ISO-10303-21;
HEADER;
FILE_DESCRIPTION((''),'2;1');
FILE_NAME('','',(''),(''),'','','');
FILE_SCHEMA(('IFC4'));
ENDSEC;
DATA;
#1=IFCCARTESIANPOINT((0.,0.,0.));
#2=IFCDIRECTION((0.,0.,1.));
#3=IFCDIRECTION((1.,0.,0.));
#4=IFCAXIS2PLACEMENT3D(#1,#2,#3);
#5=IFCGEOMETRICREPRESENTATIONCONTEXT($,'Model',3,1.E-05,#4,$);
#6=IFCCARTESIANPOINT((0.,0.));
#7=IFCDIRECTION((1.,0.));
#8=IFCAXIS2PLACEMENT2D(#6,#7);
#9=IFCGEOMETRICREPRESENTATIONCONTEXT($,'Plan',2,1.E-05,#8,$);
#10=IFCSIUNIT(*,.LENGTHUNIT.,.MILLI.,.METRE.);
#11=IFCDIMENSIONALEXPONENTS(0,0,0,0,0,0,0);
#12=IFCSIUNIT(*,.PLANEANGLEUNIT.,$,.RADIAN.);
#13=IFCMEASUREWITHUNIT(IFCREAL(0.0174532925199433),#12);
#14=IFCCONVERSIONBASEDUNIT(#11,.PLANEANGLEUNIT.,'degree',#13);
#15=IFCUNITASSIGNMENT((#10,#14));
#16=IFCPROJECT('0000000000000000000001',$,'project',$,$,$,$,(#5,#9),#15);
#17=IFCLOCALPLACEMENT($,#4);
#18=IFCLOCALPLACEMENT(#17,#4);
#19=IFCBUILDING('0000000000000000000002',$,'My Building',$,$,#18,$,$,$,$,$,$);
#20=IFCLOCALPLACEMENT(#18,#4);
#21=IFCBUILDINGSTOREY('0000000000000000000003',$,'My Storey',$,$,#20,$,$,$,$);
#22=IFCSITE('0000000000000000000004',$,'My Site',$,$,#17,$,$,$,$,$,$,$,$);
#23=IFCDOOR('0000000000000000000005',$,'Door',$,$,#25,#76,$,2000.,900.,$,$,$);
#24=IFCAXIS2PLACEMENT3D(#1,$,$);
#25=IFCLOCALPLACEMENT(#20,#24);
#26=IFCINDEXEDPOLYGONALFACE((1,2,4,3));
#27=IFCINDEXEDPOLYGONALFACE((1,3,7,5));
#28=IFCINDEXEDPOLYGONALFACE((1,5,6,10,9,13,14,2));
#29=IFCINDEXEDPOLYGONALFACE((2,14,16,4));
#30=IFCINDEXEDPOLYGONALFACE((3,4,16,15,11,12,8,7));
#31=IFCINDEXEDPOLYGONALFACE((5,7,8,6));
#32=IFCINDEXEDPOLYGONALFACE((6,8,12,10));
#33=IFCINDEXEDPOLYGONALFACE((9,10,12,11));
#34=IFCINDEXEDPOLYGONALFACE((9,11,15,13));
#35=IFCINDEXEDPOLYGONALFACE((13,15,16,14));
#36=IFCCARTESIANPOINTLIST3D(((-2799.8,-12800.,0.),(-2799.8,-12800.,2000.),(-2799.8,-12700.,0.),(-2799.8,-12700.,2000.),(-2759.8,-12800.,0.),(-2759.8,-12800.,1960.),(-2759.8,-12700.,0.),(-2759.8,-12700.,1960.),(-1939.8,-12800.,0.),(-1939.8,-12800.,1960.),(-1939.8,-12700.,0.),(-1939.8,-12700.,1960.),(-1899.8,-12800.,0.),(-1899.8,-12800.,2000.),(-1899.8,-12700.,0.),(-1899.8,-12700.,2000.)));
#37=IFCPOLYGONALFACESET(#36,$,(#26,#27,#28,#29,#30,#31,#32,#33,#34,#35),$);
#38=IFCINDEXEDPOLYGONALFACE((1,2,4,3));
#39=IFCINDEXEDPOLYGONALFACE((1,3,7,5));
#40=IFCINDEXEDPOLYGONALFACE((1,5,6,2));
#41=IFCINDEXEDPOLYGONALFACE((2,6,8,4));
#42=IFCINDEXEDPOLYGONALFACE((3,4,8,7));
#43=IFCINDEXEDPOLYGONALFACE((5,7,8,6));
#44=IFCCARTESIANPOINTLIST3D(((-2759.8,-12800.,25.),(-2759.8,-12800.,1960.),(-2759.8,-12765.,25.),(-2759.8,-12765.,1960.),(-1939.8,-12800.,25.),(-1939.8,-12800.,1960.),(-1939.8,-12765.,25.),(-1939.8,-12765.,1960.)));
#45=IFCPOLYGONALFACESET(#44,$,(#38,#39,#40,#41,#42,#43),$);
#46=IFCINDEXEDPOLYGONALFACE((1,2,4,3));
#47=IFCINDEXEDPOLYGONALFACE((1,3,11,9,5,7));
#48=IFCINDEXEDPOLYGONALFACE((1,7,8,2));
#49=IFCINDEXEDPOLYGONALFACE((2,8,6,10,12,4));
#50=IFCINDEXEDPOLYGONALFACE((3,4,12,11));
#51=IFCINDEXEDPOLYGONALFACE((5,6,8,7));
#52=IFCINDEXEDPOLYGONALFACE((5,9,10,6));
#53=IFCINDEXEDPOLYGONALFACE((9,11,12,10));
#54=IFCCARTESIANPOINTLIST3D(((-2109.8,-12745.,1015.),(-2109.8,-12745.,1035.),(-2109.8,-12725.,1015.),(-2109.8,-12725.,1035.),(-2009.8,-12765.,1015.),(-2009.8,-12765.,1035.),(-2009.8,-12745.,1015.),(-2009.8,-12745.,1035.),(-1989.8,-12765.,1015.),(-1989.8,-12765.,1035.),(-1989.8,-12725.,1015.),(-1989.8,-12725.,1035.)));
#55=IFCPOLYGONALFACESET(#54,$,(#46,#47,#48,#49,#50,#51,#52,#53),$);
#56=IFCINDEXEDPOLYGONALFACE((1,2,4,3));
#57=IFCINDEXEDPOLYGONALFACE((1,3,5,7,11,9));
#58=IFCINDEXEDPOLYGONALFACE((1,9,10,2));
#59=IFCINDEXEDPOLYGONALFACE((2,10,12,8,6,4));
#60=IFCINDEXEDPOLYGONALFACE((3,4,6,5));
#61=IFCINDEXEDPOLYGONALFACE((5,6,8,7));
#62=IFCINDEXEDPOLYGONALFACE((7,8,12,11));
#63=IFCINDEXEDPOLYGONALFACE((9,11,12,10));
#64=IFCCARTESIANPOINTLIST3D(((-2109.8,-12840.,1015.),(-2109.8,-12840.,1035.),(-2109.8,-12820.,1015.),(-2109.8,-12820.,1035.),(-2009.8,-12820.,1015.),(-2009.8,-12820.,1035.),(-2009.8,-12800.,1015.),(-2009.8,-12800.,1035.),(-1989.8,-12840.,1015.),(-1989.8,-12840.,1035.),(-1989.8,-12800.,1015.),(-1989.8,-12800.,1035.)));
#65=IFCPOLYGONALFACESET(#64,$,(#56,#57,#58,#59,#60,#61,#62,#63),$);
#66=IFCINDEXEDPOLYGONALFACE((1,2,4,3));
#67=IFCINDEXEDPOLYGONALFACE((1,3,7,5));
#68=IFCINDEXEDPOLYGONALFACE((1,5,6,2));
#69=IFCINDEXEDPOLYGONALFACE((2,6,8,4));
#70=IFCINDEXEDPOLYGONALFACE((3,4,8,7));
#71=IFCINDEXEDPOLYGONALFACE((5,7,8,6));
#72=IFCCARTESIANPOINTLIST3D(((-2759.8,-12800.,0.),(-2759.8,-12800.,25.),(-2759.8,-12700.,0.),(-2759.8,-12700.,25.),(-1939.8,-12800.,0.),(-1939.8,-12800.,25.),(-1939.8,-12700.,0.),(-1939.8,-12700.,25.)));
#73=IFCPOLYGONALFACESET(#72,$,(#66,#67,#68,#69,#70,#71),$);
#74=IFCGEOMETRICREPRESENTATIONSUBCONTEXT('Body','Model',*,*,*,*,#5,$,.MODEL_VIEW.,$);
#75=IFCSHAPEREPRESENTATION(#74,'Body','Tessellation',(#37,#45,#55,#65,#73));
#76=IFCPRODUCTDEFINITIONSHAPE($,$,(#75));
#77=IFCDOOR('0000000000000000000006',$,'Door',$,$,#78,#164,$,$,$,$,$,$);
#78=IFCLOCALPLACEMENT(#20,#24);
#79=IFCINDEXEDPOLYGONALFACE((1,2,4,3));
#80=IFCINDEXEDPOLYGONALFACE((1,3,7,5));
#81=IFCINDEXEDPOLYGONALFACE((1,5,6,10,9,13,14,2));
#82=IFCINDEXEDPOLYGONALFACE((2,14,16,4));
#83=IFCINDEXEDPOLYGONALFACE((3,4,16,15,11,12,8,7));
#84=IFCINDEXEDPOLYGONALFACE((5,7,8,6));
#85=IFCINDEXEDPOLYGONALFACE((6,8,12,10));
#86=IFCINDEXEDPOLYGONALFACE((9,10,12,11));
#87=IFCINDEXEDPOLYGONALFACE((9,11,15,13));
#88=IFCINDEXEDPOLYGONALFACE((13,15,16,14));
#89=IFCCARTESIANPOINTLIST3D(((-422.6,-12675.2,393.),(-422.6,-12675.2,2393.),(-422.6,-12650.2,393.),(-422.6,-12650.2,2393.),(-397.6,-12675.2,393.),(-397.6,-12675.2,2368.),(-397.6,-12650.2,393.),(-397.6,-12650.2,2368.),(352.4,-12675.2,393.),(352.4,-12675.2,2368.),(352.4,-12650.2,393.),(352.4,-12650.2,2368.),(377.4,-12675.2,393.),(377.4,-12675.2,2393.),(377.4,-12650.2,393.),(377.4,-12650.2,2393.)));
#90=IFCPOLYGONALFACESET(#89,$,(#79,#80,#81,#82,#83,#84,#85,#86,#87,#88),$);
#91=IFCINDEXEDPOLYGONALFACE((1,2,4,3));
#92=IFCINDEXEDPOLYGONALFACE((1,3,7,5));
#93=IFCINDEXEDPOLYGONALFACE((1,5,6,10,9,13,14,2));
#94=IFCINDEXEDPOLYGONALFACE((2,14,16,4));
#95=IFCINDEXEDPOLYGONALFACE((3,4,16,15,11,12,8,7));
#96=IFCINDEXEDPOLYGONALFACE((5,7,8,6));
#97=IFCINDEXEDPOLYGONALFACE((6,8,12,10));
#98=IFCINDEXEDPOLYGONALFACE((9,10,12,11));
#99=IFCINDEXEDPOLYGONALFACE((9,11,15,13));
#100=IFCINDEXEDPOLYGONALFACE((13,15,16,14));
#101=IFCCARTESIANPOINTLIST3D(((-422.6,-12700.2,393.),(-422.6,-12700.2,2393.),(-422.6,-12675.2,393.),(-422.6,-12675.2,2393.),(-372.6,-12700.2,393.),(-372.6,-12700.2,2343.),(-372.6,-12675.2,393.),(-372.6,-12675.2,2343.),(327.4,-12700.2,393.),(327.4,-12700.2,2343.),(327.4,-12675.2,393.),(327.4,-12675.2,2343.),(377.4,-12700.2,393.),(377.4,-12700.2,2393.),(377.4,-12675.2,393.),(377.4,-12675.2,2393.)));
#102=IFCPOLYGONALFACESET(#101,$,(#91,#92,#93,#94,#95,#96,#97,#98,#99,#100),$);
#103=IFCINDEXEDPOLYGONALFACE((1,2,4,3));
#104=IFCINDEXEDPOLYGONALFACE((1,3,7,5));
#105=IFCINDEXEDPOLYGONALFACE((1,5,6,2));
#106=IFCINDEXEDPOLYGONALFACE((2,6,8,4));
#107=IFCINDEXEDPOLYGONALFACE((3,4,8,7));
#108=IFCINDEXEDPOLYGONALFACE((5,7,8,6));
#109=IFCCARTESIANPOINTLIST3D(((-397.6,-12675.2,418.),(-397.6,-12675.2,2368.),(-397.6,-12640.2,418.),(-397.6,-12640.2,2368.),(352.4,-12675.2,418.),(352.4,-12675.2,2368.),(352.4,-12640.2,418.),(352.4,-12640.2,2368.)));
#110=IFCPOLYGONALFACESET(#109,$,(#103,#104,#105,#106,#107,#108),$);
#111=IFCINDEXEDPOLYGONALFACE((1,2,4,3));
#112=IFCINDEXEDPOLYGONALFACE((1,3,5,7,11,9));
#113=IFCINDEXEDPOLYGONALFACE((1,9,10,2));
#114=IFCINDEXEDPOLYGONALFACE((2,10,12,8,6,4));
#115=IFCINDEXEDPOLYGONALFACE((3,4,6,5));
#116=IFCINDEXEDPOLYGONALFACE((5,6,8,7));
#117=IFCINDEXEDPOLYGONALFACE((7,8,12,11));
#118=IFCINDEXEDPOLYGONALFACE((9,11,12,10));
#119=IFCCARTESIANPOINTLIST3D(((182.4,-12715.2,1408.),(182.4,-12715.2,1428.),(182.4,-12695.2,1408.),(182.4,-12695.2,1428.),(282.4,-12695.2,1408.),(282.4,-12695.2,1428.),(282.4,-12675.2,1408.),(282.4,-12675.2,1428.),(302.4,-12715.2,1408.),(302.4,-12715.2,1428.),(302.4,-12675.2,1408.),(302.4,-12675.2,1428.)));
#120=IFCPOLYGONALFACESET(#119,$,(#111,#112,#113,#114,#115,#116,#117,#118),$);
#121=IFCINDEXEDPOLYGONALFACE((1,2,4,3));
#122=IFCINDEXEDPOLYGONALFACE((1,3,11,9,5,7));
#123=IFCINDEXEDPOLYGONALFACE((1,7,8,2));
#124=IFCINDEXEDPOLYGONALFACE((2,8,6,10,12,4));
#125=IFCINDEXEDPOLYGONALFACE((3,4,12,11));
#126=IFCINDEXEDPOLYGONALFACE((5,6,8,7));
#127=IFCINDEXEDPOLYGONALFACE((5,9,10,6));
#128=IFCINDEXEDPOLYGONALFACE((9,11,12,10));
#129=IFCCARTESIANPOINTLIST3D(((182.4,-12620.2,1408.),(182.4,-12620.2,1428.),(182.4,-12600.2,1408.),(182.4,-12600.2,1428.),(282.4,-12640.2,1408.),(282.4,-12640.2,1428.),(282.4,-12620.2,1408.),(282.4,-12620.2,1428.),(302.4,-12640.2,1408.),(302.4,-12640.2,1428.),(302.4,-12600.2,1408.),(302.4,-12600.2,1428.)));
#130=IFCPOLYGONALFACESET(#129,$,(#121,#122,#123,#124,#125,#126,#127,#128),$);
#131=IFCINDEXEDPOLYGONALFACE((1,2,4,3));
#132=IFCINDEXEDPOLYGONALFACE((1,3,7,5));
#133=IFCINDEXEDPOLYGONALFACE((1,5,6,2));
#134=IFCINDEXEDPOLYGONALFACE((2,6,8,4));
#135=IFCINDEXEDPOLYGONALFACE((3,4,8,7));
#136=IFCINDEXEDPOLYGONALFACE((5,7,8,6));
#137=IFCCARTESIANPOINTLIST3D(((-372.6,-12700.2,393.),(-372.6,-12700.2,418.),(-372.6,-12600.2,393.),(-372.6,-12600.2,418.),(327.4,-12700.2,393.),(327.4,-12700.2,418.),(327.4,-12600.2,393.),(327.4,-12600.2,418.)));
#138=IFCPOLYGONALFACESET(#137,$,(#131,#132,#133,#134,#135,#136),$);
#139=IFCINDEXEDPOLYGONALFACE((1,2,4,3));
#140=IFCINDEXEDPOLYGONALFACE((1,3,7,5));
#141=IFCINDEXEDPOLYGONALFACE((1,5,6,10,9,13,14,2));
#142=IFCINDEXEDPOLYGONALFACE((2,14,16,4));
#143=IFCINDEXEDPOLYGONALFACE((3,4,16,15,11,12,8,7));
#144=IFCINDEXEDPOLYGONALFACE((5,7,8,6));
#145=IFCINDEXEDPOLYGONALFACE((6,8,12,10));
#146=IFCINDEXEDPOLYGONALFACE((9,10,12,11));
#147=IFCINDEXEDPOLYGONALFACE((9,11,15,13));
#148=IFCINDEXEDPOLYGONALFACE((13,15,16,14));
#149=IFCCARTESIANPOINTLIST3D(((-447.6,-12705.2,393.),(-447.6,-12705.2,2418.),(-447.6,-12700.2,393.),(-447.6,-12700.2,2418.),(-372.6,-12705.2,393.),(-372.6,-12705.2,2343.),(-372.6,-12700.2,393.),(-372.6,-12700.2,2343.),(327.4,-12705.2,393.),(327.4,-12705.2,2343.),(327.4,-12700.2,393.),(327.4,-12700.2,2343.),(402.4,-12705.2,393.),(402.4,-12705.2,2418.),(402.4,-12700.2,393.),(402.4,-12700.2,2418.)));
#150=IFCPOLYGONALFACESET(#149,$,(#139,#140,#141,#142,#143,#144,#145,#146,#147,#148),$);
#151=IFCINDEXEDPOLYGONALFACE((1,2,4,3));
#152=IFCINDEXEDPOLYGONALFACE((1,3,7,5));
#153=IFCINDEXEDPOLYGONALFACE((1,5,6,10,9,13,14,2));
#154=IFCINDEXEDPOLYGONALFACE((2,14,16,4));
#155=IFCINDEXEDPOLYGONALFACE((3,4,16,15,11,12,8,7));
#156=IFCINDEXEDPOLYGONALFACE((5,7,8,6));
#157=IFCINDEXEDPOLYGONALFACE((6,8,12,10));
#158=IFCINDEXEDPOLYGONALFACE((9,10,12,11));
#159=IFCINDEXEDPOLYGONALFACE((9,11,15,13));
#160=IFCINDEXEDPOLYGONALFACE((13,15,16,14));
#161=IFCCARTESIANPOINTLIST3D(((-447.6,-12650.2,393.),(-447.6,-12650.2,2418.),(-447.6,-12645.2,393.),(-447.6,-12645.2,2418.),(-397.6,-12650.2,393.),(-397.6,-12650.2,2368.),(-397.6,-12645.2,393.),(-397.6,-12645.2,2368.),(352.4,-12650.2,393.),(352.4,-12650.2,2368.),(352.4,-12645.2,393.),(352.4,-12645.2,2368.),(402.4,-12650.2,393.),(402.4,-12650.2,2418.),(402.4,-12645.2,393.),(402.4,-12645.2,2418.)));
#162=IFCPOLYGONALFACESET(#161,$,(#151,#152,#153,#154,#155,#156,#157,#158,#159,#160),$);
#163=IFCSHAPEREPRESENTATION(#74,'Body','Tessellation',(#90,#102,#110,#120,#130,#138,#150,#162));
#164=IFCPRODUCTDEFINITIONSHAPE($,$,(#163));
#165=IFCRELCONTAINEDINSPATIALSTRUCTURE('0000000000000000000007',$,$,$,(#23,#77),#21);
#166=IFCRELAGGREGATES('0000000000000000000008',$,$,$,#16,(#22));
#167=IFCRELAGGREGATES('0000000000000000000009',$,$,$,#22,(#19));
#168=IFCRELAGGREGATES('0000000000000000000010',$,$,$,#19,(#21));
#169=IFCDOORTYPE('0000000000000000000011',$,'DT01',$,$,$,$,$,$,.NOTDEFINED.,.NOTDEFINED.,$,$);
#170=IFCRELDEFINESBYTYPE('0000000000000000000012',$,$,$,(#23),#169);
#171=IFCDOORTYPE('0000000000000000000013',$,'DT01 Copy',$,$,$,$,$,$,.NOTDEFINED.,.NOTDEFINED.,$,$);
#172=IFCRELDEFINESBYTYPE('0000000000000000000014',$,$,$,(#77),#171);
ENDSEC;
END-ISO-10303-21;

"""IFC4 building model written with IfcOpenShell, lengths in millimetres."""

from ifc_helpers import new_model, entity, si_unit, converted_unit, frame, origin_with_axes, origin_2d_with_axis, place, context, subcontext, project, spatial, line, indexed_curve, outline, extrude, shape, source, transform, mapped, type_object, type_shapes, element, save


model = new_model("IFC4")

# Units and contexts
model_context = context("Model", 3, precision=1e-05, world=origin_with_axes())
plan_context = context("Plan", 2, precision=1e-05, world=origin_2d_with_axis())
body_context_1 = subcontext(model_context, "Body", "Model", "MODEL_VIEW")
body_context_2 = subcontext(plan_context, "Body", "Plan", "PLAN_VIEW")
ifc_project = project(units=[si_unit("LENGTHUNIT", "METRE", prefix="MILLI"), converted_unit("PLANEANGLEUNIT", "degree", entity("IfcReal", 0.0174532925199433), si_unit("PLANEANGLEUNIT", "RADIAN"), dimensions=[0, 0, 0, 0, 0, 0, 0])], contexts=[model_context, plan_context])

# Site, building, storey
site_placement = place(None, origin_with_axes())
site = spatial("IfcSite", under=ifc_project, at=site_placement, Name="My Site")
building_placement = place(site_placement, origin_with_axes())
building = spatial("IfcBuilding", under=site, at=building_placement, Name="My Building")
storey_placement = place(building_placement, origin_with_axes())
storey = spatial("IfcBuildingStorey", under=building, at=storey_placement, Name="My Storey")

# Shared definitions
door_type_1 = type_object("IfcDoorType", Name="DT01", OperationType="NOTDEFINED", PredefinedType="NOTDEFINED")
shared_shape_1 = source(origin_with_axes(), body_context_1, "Body", "SweptSolid", [
    extrude(outline(indexed_curve([(0.0, 0.0), (0.0, 2000.0), (900.0, 2000.0), (900.0, 0.0), (860.0, 0.0), (860.0, 1960.0), (40.0, 1960.0), (40.0, 0.0)], segments=[line(1, 2, 3, 4, 5, 6, 7, 8, 1)])), frame((0.0, 0.0, 0.0), z_axis=(0.0, -1.0, 0.0), x_axis=(1.0, 0.0, 0.0)), (0.0, 0.0, -1.0), 100.0),
    extrude(outline(indexed_curve([(0.0, 0.0), (820.0, 0.0), (820.0, 35.0), (0.0, 35.0)], segments=[line(1, 2, 3, 4, 1)])), frame((40.0, 65.0, 25.0), z_axis=(0.0, 0.0, 1.0), x_axis=(1.0, 0.0, 0.0)), (0.0, 0.0, 1.0), 1935.0),
    extrude(outline(indexed_curve([(0.0, 0.0), (0.0, -40.0), (120.0, -40.0), (120.0, -20.0), (20.0, -20.0), (20.0, 0.0)], segments=[line(1, 2, 3, 4, 5, 6, 1)])), frame((90.0, 65.0, 1015.0), z_axis=(0.0, 0.0, 1.0), x_axis=(1.0, 0.0, 0.0)), (0.0, 0.0, 1.0), 20.0),
    extrude(outline(indexed_curve([(0.0, 0.0), (0.0, 40.0), (120.0, 40.0), (120.0, 20.0), (20.0, 20.0), (20.0, 0.0)], segments=[line(1, 2, 3, 4, 5, 6, 1)])), frame((90.0, 100.0, 1015.0), z_axis=(0.0, 0.0, 1.0), x_axis=(1.0, 0.0, 0.0)), (0.0, 0.0, 1.0), 20.0),
    extrude(outline(indexed_curve([(0.0, 0.0), (820.0, 0.0), (820.0, 100.0), (0.0, 100.0)], segments=[line(1, 2, 3, 4, 1)])), frame((40.0, 0.0, 0.0), z_axis=(0.0, 0.0, 1.0), x_axis=(1.0, 0.0, 0.0)), (0.0, 0.0, 1.0), 25.0),
])
shared_shape_2 = source(origin_with_axes(), body_context_2, "Body", "Curve2D", [
    entity("IfcIndexedPolyCurve", entity("IfcCartesianPointList2D", [[0.0, 0.0], [40.0, 0.0], [40.0, 100.0], [0.0, 100.0]]), [entity("IfcLineIndex", [1, 2, 3, 4, 1])]),
    entity("IfcIndexedPolyCurve", entity("IfcCartesianPointList2D", [[900.0, 0.0], [860.0, 0.0], [860.0, 100.0], [900.0, 100.0]]), [entity("IfcLineIndex", [1, 2, 3, 4, 1])]),
    entity("IfcTrimmedCurve", entity("IfcEllipse", entity("IfcAxis2Placement2D", entity("IfcCartesianPoint", [825.0, 100.0]), entity("IfcDirection", [1.0, 0.0])), 785.0, 820.0), [entity("IfcCartesianPoint", [825.0, 920.0])], [entity("IfcCartesianPoint", [40.0, 100.0])], True, "CARTESIAN"),
    entity("IfcIndexedPolyCurve", entity("IfcCartesianPointList2D", [[860.0, 100.0], [825.0, 100.0], [825.0, 920.0], [860.0, 920.0]]), [entity("IfcLineIndex", [1, 2, 3, 4, 1])]),
])
type_shapes(door_type_1, [shared_shape_1, shared_shape_2])

# Doors
placement_1 = place(storey_placement, frame((1900.0, -12600.0, 0.0), z_axis=(0.0, 0.0, 1.0), x_axis=(-1.0, 0.000003, 0.0)))
placement_2 = place(placement_1, frame((3799.8, 100.0, 0.0), z_axis=(0.0, 0.0, 1.0), x_axis=(1.0, 0.000006, 0.0)))
door_1_placement = place(placement_2, frame((0.0, 0.0, 0.0), z_axis=(0.0, 0.0, 1.0), x_axis=(1.0, 0.0, 0.0)))
element("IfcDoor", 1, at=door_1_placement, inside=storey, type_object=door_type_1, Name="Door", OverallHeight=2000.0, OverallWidth=900.0, shapes=[
    shape(body_context_1, "Body", "MappedRepresentation", [mapped(shared_shape_1, transform((0.0, 0.0, 0.0), x_axis=(1.0, 0.0, 0.0), y_axis=(0.0, 1.0, 0.0), z_axis=(0.0, 0.0, 1.0), scale=1.0))]),
    shape(body_context_2, "Body", "MappedRepresentation", [mapped(shared_shape_2, transform((0.0, 0.0, 0.0), x_axis=(1.0, 0.0, 0.0), y_axis=(0.0, 1.0, 0.0), z_axis=(0.0, 0.0, 1.0), scale=1.0))]),
])
door_type_2 = type_object("IfcDoorType", Name="DT01 Copy", OperationType="NOTDEFINED", PredefinedType="NOTDEFINED")
shared_shape_3 = source(origin_with_axes(), body_context_1, "Body", "SweptSolid", [
    extrude(outline(indexed_curve([(0.0, 0.0), (0.0, 2000.0), (800.0, 2000.0), (800.0, 0.0), (775.0, 0.0), (775.0, 1975.0), (25.0, 1975.0), (25.0, 0.0)], segments=[line(1, 2, 3, 4, 5, 6, 7, 8, 1)])), frame((0.0, 25.0, 0.0), z_axis=(0.0, -1.0, 0.0), x_axis=(1.0, 0.0, 0.0)), (0.0, 0.0, -1.0), 25.0),
    extrude(outline(indexed_curve([(0.0, 0.0), (0.0, 2000.0), (800.0, 2000.0), (800.0, 0.0), (750.0, 0.0), (750.0, 1950.0), (50.0, 1950.0), (50.0, 0.0)], segments=[line(1, 2, 3, 4, 5, 6, 7, 8, 1)])), frame((0.0, 0.0, 0.0), z_axis=(0.0, -1.0, 0.0), x_axis=(1.0, 0.0, 0.0)), (0.0, 0.0, -1.0), 25.0),
    extrude(outline(indexed_curve([(0.0, 0.0), (750.0, 0.0), (750.0, 35.0), (0.0, 35.0)], segments=[line(1, 2, 3, 4, 1)])), frame((25.0, 25.0, 25.0), z_axis=(0.0, 0.0, 1.0), x_axis=(1.0, 0.0, 0.0)), (0.0, 0.0, 1.0), 1950.0),
    extrude(outline(indexed_curve([(0.0, 0.0), (0.0, -40.0), (-120.0, -40.0), (-120.0, -20.0), (-20.0, -20.0), (-20.0, 0.0)], segments=[line(1, 2, 3, 4, 5, 6, 1)])), frame((725.0, 25.0, 1015.0), z_axis=(0.0, 0.0, 1.0), x_axis=(1.0, 0.0, 0.0)), (0.0, 0.0, 1.0), 20.0),
    extrude(outline(indexed_curve([(0.0, 0.0), (0.0, 40.0), (-120.0, 40.0), (-120.0, 20.0), (-20.0, 20.0), (-20.0, 0.0)], segments=[line(1, 2, 3, 4, 5, 6, 1)])), frame((725.0, 60.0, 1015.0), z_axis=(0.0, 0.0, 1.0), x_axis=(1.0, 0.0, 0.0)), (0.0, 0.0, 1.0), 20.0),
    extrude(outline(indexed_curve([(0.0, 0.0), (700.0, 0.0), (700.0, 100.0), (0.0, 100.0)], segments=[line(1, 2, 3, 4, 1)])), frame((50.0, 0.0, 0.0), z_axis=(0.0, 0.0, 1.0), x_axis=(1.0, 0.0, 0.0)), (0.0, 0.0, 1.0), 25.0),
    extrude(outline(indexed_curve([(0.0, 0.0), (0.0, 2025.0), (850.0, 2025.0), (850.0, 0.0), (775.0, 0.0), (775.0, 1950.0), (75.0, 1950.0), (75.0, 0.0)], segments=[line(1, 2, 3, 4, 5, 6, 7, 8, 1)])), frame((-25.0, -5.0, 0.0), z_axis=(0.0, -1.0, 0.0), x_axis=(1.0, 0.0, 0.0)), (0.0, 0.0, -1.0), 5.0),
    extrude(outline(indexed_curve([(0.0, 0.0), (0.0, 2025.0), (850.0, 2025.0), (850.0, 0.0), (800.0, 0.0), (800.0, 1975.0), (50.0, 1975.0), (50.0, 0.0)], segments=[line(1, 2, 3, 4, 5, 6, 7, 8, 1)])), frame((-25.0, 50.0, 0.0), z_axis=(0.0, -1.0, 0.0), x_axis=(1.0, 0.0, 0.0)), (0.0, 0.0, -1.0), 5.0),
])
shared_shape_4 = source(origin_with_axes(), body_context_2, "Body", "Curve2D", [
    entity("IfcIndexedPolyCurve", entity("IfcCartesianPointList2D", [[0.0, 0.0], [0.0, 50.0], [25.0, 50.0], [25.0, 25.0], [50.0, 25.0], [50.0, 0.0]]), [entity("IfcLineIndex", [1, 2, 3, 4, 5, 6, 1])]),
    entity("IfcIndexedPolyCurve", entity("IfcCartesianPointList2D", [[800.0, 0.0], [800.0, 50.0], [775.0, 50.0], [775.0, 25.0], [750.0, 25.0], [750.0, 0.0]]), [entity("IfcLineIndex", [1, 2, 3, 4, 5, 6, 1])]),
    entity("IfcTrimmedCurve", entity("IfcEllipse", entity("IfcAxis2Placement2D", entity("IfcCartesianPoint", [60.0, 50.0]), entity("IfcDirection", [1.0, 0.0])), 715.0, 750.0), [entity("IfcCartesianPoint", [775.0, 50.0])], [entity("IfcCartesianPoint", [60.0, 800.0])], True, "CARTESIAN"),
    entity("IfcIndexedPolyCurve", entity("IfcCartesianPointList2D", [[25.0, 50.0], [60.0, 50.0], [60.0, 800.0], [25.0, 800.0]]), [entity("IfcLineIndex", [1, 2, 3, 4, 1])]),
])
type_shapes(door_type_2, [shared_shape_3, shared_shape_4])
door_2_placement = place(storey_placement, frame((-422.6, -12700.2, 393.0), z_axis=(0.0, 0.0, 1.0), x_axis=(1.0, 0.0, 0.0)))
element("IfcDoor", 2, at=door_2_placement, inside=storey, type_object=door_type_2, Name="Door", shapes=[
    shape(body_context_1, "Body", "MappedRepresentation", [mapped(shared_shape_3, transform((0.0, 0.0, 0.0), x_axis=(1.0, 0.0, 0.0), y_axis=(0.0, 1.0, 0.0), z_axis=(0.0, 0.0, 1.0), scale=1.0))]),
    shape(body_context_2, "Body", "MappedRepresentation", [mapped(shared_shape_4, transform((0.0, 0.0, 0.0), x_axis=(1.0, 0.0, 0.0), y_axis=(0.0, 1.0, 0.0), z_axis=(0.0, 0.0, 1.0), scale=1.0))]),
])

save(model, "model.ifc")
